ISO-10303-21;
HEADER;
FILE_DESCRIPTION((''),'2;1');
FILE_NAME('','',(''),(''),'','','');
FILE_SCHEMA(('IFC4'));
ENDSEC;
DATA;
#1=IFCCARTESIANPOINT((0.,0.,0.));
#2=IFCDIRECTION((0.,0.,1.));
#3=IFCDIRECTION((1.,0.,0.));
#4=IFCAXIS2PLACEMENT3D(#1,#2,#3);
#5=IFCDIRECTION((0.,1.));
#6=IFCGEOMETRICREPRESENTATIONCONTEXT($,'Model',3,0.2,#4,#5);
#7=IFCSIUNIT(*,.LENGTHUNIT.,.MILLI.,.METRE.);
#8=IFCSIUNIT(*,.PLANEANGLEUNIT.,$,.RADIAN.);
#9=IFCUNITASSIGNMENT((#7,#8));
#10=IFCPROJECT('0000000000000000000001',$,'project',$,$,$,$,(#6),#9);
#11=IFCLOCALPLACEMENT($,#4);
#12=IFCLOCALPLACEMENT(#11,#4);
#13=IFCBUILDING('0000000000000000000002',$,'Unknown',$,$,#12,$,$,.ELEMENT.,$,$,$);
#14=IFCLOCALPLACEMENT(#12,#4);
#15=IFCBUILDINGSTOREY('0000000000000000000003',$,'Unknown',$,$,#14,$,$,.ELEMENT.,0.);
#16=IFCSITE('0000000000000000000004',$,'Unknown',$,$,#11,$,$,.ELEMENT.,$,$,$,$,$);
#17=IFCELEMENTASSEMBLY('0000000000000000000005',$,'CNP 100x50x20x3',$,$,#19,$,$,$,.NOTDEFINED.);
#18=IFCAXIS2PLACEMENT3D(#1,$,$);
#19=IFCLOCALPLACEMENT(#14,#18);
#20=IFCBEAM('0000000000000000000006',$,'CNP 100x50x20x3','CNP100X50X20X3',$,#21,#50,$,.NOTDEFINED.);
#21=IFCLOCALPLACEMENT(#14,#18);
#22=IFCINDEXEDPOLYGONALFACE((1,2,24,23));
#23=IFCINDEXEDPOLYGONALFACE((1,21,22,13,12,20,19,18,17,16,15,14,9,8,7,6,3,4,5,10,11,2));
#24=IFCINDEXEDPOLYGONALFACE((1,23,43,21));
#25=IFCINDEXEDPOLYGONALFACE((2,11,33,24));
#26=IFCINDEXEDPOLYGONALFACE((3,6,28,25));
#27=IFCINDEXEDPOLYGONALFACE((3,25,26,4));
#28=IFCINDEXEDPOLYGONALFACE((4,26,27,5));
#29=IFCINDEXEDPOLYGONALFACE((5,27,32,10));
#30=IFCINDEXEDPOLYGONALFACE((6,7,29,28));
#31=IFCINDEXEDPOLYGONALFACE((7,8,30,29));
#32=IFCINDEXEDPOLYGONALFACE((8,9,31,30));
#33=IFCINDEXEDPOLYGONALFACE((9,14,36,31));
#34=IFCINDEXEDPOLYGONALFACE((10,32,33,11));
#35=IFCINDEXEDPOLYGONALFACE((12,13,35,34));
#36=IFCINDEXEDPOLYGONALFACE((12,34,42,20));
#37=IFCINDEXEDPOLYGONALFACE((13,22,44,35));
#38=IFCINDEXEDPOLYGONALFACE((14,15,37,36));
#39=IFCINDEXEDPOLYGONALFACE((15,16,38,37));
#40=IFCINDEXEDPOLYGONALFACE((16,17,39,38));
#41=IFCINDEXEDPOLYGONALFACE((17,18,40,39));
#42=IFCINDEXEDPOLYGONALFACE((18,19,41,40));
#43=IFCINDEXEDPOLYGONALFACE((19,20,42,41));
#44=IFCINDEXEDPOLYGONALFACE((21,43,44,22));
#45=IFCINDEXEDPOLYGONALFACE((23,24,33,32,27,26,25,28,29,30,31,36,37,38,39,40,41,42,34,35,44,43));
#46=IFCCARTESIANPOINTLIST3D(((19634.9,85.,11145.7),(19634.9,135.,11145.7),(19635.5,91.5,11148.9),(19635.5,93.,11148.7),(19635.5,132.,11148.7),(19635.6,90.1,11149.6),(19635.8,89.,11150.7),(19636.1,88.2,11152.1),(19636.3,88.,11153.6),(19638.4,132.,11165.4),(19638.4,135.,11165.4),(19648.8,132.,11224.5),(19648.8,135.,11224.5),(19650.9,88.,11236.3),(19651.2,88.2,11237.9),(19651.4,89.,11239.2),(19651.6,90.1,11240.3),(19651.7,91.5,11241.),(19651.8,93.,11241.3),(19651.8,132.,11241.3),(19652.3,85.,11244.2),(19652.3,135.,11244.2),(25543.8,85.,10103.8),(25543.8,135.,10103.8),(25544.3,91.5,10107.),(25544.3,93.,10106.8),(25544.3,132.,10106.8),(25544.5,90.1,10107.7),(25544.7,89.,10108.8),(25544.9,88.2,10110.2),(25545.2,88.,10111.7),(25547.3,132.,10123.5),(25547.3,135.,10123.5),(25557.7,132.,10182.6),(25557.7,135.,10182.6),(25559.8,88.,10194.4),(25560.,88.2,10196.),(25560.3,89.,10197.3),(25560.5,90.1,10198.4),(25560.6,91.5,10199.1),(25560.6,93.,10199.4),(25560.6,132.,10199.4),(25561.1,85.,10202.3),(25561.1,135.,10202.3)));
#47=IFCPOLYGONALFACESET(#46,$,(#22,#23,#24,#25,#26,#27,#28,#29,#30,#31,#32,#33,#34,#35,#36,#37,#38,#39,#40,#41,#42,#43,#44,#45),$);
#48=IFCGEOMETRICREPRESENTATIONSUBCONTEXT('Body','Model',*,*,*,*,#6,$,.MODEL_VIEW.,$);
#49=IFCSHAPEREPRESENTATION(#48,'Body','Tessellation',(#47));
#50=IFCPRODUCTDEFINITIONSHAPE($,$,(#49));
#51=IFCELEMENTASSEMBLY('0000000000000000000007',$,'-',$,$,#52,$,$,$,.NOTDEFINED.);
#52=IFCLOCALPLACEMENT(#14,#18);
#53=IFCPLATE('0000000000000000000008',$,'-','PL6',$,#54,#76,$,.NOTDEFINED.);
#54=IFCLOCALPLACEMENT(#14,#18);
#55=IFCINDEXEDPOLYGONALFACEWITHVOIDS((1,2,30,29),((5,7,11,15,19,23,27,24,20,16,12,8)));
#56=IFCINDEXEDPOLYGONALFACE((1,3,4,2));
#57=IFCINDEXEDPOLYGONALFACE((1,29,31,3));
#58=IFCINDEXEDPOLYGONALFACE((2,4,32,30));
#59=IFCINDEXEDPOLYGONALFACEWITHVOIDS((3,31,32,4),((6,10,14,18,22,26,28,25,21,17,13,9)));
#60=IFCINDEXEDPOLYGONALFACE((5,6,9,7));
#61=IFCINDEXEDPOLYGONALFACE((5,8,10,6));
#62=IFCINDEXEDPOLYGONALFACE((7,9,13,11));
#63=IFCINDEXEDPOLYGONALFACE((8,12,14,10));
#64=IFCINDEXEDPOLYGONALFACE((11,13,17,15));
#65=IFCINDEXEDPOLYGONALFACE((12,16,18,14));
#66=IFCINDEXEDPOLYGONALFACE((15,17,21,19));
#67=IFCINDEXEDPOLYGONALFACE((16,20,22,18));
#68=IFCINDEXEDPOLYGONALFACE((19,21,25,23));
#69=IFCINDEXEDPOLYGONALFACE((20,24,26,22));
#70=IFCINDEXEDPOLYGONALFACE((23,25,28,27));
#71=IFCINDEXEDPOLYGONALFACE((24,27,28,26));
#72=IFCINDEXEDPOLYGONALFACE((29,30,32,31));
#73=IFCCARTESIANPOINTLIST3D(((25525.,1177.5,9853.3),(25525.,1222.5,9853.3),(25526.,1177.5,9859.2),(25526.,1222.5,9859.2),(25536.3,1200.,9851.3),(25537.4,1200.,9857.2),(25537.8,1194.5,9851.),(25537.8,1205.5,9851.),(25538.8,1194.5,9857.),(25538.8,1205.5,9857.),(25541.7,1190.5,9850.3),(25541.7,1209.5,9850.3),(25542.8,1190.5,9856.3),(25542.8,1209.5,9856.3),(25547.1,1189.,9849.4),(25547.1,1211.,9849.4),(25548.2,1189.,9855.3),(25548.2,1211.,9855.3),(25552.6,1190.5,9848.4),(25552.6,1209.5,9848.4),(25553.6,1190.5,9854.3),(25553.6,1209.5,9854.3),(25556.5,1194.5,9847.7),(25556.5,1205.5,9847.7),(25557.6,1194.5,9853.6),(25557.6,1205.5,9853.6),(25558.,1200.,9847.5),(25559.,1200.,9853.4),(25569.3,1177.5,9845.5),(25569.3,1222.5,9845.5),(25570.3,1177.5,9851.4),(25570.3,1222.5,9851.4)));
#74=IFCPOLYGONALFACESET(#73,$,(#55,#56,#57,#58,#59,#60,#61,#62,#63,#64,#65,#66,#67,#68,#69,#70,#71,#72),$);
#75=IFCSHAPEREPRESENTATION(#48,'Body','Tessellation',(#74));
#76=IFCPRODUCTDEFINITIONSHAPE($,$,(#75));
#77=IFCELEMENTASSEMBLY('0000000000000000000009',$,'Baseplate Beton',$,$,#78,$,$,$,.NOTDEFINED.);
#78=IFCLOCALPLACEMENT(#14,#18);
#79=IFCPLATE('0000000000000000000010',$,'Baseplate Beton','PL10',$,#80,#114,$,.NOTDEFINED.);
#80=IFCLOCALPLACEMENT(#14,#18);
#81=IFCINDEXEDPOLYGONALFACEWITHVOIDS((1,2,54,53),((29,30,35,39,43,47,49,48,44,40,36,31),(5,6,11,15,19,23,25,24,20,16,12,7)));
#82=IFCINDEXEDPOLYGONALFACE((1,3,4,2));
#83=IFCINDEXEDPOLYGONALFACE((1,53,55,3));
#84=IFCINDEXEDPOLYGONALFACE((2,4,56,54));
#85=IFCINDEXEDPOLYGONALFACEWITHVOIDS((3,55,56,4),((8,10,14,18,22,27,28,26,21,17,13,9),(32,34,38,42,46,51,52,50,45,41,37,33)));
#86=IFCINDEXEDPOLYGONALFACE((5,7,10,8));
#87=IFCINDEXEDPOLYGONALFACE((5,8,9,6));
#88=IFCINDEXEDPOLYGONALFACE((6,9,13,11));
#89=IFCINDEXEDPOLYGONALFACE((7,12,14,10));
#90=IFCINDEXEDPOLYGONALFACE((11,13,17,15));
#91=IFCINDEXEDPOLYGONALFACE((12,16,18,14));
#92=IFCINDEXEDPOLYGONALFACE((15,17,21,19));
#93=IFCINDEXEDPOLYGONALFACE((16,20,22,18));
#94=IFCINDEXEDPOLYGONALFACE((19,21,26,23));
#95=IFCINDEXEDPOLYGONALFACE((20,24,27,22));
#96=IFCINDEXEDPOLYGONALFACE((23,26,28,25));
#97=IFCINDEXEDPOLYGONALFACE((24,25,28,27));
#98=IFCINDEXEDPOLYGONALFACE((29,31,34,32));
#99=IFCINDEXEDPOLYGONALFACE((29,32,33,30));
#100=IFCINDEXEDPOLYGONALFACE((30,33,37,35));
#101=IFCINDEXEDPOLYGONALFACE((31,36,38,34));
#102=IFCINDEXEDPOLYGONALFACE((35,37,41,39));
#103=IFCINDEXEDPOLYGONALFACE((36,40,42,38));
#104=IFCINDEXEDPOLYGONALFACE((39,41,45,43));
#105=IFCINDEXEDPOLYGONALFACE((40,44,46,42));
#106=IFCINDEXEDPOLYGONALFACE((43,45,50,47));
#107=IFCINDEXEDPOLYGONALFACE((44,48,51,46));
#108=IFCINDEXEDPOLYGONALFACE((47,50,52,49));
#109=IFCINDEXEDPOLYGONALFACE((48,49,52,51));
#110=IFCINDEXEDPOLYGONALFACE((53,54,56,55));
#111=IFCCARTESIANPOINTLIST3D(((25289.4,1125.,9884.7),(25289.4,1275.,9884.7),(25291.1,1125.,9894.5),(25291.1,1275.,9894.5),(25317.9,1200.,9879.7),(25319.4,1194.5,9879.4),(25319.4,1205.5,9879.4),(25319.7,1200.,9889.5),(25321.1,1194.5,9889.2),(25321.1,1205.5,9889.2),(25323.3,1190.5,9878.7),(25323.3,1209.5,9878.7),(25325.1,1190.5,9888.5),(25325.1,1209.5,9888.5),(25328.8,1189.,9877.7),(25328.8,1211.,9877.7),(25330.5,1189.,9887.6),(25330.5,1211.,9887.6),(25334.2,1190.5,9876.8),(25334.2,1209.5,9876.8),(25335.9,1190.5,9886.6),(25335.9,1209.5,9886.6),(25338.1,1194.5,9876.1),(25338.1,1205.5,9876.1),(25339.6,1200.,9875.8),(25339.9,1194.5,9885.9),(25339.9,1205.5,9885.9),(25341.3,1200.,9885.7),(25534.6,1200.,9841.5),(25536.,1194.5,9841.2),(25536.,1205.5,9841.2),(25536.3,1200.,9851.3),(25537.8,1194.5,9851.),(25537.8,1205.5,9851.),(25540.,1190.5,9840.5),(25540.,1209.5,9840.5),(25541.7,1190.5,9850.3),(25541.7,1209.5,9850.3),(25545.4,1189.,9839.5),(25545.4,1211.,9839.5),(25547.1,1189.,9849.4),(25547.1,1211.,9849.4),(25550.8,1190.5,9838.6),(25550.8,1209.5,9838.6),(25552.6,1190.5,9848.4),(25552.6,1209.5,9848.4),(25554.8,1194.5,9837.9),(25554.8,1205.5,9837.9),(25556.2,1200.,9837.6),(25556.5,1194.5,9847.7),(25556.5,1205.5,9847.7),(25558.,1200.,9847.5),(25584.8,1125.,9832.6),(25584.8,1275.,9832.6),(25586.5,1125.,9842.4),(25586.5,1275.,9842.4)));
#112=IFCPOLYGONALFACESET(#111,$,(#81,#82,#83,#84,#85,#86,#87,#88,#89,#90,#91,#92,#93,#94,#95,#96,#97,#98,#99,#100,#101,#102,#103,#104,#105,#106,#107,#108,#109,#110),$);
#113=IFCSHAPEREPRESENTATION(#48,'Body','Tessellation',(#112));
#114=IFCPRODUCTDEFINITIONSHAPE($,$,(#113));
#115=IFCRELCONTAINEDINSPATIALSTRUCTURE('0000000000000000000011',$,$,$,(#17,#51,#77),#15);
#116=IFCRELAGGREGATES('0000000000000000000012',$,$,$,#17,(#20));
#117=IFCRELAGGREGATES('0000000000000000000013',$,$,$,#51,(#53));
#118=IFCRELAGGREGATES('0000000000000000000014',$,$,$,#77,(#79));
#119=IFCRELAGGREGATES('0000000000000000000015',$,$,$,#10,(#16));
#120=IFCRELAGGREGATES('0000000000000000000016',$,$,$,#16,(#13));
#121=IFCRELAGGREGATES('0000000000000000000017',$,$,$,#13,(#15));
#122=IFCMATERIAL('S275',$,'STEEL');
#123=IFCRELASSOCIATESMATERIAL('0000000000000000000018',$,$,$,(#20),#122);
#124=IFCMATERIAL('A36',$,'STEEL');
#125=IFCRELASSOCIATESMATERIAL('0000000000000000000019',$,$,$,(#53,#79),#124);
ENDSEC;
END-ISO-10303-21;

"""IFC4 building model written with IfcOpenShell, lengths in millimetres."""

from ifc_helpers import new_model, si_unit, direction, frame, origin_with_axes, place, context, subcontext, project, spatial, line, indexed_curve, outline, extrude, material, element, aggregate, save


model = new_model("IFC4")

# Units and contexts
model_context = context("Model", 3, precision=0.2, world=origin_with_axes(), true_north=direction((0.0, 1.0)))
body_context = subcontext(model_context, "Body", "Model", "MODEL_VIEW")
ifc_project = project(units=[si_unit("LENGTHUNIT", "METRE", prefix="MILLI"), si_unit("PLANEANGLEUNIT", "RADIAN")], contexts=[model_context])

# Site, building, storey
site_placement = place(None, origin_with_axes())
site = spatial("IfcSite", under=ifc_project, at=site_placement, Name="Unknown", CompositionType="ELEMENT")
building_placement = place(site_placement, origin_with_axes())
building = spatial("IfcBuilding", under=site, at=building_placement, Name="Unknown", CompositionType="ELEMENT")
storey_placement = place(building_placement, origin_with_axes())
storey = spatial("IfcBuildingStorey", under=building, at=storey_placement, Name="Unknown", CompositionType="ELEMENT", Elevation=0.0)

# Shared definitions
ifc_material_1 = material(Name="S275", Category="STEEL")

# Element assembly, beam
assembly_1_placement = place(storey_placement, frame((25552.5, 110.0, 10153.1), z_axis=(0.173648, 0.0, 0.984808), x_axis=(-0.984808, 0.0, 0.173648)))
assembly_1 = element("IfcElementAssembly", 1, at=assembly_1_placement, inside=storey, Name="CNP 100x50x20x3", PredefinedType="NOTDEFINED")
beam_1_placement = place(assembly_1_placement, origin_with_axes())
beam_1 = element("IfcBeam", 2, at=beam_1_placement, material=ifc_material_1, Name="CNP 100x50x20x3", Description="CNP100X50X20X3", PredefinedType="NOTDEFINED", context=body_context, shape_type="SolidModel", body=[
    extrude(outline(indexed_curve([(50.0, -25.0), (50.0, 25.0), (-50.0, 25.0), (-50.0, -25.0), (-30.0, -25.0), (-30.0, -22.0), (-47.0, -22.0), (-47.0, 17.0), (-46.8, 18.5), (-46.0, 19.9), (-44.9, 21.0), (-43.5, 21.8), (-42.0, 22.0), (42.0, 22.0), (43.5, 21.8), (44.9, 21.0), (46.0, 19.9), (46.8, 18.5), (47.0, 17.0), (47.0, -22.0), (30.0, -22.0), (30.0, -25.0)], segments=[line(1, 2, 3, 4, 5, 6, 7, 8, 9, 10, 11, 12, 13, 14, 15, 16, 17, 18, 19, 20, 21, 22, 1)])), frame((0.0, 0.0, 0.0), z_axis=(-1.0, 0.0, 0.0), x_axis=(0.0, 0.0, 1.0)), (0.0, 0.0, -1.0), 6000.0),
])
aggregate(assembly_1, [beam_1])

# Element assembly, plate, voiding feature
assembly_2_placement = place(storey_placement, frame((25525.5, 1177.5, 9856.3), z_axis=(-0.173648, 0.0, -0.984808), x_axis=(0.0, 1.0, 0.0)))
assembly_2 = element("IfcElementAssembly", 3, at=assembly_2_placement, inside=storey, Name="-", PredefinedType="NOTDEFINED")
ifc_material_2 = material(Name="A36", Category="STEEL")
plate_1_placement = place(assembly_2_placement, origin_with_axes())
plate_1 = element("IfcPlate", 4, at=plate_1_placement, material=ifc_material_2, Name="-", Description="PL6", PredefinedType="NOTDEFINED", context=body_context, shape_type="SolidModel", body=[
    extrude(outline(indexed_curve([(0.0, 0.0), (45.0, 0.0), (45.0, 45.0), (0.0, 45.0)], segments=[line(1, 2, 3, 4, 1)])), frame((0.0, 0.0, 3.0), z_axis=(0.0, 0.0, 1.0), x_axis=(1.0, 0.0, 0.0)), (0.0, 0.0, -1.0), 6.0),
])
voiding_feature_1_placement = place(plate_1_placement, frame((22.5, 22.5, -3.5), z_axis=(-1.0, 0.0, 0.0), x_axis=(0.0, 0.0, 1.0)))
element("IfcVoidingFeature", 5, at=voiding_feature_1_placement, cuts=plate_1, Name="BEAM", PredefinedType="HOLE", context=body_context, shape_type="SolidModel", body=[
    extrude(outline(indexed_curve([(11.0, 0.0), (9.5, 5.5), (5.5, 9.5), (0.0, 11.0), (-5.5, 9.5), (-9.5, 5.5), (-11.0, 0.0), (-9.5, -5.5), (-5.5, -9.5), (0.0, -11.0), (5.5, -9.5), (9.5, -5.5)], segments=[line(1, 2, 3, 4, 5, 6, 7, 8, 9, 10, 11, 12, 1)])), frame((0.0, 0.0, 0.0), z_axis=(-1.0, 0.0, 0.0), x_axis=(0.0, 0.0, 1.0)), (0.0, 0.0, -1.0), 7.0),
])
aggregate(assembly_2, [plate_1])

# Element assembly, plate, voiding features
assembly_3_placement = place(storey_placement, frame((25585.7, 1125.0, 9837.5), z_axis=(0.173648, 0.0, 0.984808), x_axis=(0.0, 1.0, 0.0)))
assembly_3 = element("IfcElementAssembly", 6, at=assembly_3_placement, inside=storey, Name="Baseplate Beton", PredefinedType="NOTDEFINED")
plate_2_placement = place(assembly_3_placement, origin_with_axes())
plate_2 = element("IfcPlate", 7, at=plate_2_placement, material=ifc_material_2, Name="Baseplate Beton", Description="PL10", PredefinedType="NOTDEFINED", context=body_context, shape_type="SolidModel", body=[
    extrude(outline(indexed_curve([(0.0, 0.0), (150.0, 0.0), (150.0, 300.0), (0.0, 300.0)], segments=[line(1, 2, 3, 4, 1)])), frame((0.0, 0.0, 5.0), z_axis=(0.0, 0.0, 1.0), x_axis=(1.0, 0.0, 0.0)), (0.0, 0.0, -1.0), 10.0),
])
voiding_feature_2_placement = place(plate_2_placement, frame((75.0, 260.0, 5.5), z_axis=(1.0, 0.0, 0.0), x_axis=(0.0, 0.0, -1.0)))
element("IfcVoidingFeature", 8, at=voiding_feature_2_placement, cuts=plate_2, Name="BEAM", PredefinedType="HOLE", context=body_context, shape_type="SolidModel", body=[
    extrude(outline(indexed_curve([(11.0, 0.0), (9.5, 5.5), (5.5, 9.5), (0.0, 11.0), (-5.5, 9.5), (-9.5, 5.5), (-11.0, 0.0), (-9.5, -5.5), (-5.5, -9.5), (0.0, -11.0), (5.5, -9.5), (9.5, -5.5)], segments=[line(1, 2, 3, 4, 5, 6, 7, 8, 9, 10, 11, 12, 1)])), frame((0.0, 0.0, 0.0), z_axis=(-1.0, 0.0, 0.0), x_axis=(0.0, 0.0, 1.0)), (0.0, 0.0, -1.0), 11.0),
])
voiding_feature_3_placement = place(plate_2_placement, frame((75.0, 40.0, 5.5), z_axis=(1.0, 0.0, 0.0), x_axis=(0.0, 0.0, -1.0)))
element("IfcVoidingFeature", 9, at=voiding_feature_3_placement, cuts=plate_2, Name="BEAM", PredefinedType="HOLE", context=body_context, shape_type="SolidModel", body=[
    extrude(outline(indexed_curve([(11.0, 0.0), (9.5, 5.5), (5.5, 9.5), (0.0, 11.0), (-5.5, 9.5), (-9.5, 5.5), (-11.0, 0.0), (-9.5, -5.5), (-5.5, -9.5), (0.0, -11.0), (5.5, -9.5), (9.5, -5.5)], segments=[line(1, 2, 3, 4, 5, 6, 7, 8, 9, 10, 11, 12, 1)])), frame((0.0, 0.0, 0.0), z_axis=(-1.0, 0.0, 0.0), x_axis=(0.0, 0.0, 1.0)), (0.0, 0.0, -1.0), 11.0),
])
aggregate(assembly_3, [plate_2])

save(model, "model.ifc")
